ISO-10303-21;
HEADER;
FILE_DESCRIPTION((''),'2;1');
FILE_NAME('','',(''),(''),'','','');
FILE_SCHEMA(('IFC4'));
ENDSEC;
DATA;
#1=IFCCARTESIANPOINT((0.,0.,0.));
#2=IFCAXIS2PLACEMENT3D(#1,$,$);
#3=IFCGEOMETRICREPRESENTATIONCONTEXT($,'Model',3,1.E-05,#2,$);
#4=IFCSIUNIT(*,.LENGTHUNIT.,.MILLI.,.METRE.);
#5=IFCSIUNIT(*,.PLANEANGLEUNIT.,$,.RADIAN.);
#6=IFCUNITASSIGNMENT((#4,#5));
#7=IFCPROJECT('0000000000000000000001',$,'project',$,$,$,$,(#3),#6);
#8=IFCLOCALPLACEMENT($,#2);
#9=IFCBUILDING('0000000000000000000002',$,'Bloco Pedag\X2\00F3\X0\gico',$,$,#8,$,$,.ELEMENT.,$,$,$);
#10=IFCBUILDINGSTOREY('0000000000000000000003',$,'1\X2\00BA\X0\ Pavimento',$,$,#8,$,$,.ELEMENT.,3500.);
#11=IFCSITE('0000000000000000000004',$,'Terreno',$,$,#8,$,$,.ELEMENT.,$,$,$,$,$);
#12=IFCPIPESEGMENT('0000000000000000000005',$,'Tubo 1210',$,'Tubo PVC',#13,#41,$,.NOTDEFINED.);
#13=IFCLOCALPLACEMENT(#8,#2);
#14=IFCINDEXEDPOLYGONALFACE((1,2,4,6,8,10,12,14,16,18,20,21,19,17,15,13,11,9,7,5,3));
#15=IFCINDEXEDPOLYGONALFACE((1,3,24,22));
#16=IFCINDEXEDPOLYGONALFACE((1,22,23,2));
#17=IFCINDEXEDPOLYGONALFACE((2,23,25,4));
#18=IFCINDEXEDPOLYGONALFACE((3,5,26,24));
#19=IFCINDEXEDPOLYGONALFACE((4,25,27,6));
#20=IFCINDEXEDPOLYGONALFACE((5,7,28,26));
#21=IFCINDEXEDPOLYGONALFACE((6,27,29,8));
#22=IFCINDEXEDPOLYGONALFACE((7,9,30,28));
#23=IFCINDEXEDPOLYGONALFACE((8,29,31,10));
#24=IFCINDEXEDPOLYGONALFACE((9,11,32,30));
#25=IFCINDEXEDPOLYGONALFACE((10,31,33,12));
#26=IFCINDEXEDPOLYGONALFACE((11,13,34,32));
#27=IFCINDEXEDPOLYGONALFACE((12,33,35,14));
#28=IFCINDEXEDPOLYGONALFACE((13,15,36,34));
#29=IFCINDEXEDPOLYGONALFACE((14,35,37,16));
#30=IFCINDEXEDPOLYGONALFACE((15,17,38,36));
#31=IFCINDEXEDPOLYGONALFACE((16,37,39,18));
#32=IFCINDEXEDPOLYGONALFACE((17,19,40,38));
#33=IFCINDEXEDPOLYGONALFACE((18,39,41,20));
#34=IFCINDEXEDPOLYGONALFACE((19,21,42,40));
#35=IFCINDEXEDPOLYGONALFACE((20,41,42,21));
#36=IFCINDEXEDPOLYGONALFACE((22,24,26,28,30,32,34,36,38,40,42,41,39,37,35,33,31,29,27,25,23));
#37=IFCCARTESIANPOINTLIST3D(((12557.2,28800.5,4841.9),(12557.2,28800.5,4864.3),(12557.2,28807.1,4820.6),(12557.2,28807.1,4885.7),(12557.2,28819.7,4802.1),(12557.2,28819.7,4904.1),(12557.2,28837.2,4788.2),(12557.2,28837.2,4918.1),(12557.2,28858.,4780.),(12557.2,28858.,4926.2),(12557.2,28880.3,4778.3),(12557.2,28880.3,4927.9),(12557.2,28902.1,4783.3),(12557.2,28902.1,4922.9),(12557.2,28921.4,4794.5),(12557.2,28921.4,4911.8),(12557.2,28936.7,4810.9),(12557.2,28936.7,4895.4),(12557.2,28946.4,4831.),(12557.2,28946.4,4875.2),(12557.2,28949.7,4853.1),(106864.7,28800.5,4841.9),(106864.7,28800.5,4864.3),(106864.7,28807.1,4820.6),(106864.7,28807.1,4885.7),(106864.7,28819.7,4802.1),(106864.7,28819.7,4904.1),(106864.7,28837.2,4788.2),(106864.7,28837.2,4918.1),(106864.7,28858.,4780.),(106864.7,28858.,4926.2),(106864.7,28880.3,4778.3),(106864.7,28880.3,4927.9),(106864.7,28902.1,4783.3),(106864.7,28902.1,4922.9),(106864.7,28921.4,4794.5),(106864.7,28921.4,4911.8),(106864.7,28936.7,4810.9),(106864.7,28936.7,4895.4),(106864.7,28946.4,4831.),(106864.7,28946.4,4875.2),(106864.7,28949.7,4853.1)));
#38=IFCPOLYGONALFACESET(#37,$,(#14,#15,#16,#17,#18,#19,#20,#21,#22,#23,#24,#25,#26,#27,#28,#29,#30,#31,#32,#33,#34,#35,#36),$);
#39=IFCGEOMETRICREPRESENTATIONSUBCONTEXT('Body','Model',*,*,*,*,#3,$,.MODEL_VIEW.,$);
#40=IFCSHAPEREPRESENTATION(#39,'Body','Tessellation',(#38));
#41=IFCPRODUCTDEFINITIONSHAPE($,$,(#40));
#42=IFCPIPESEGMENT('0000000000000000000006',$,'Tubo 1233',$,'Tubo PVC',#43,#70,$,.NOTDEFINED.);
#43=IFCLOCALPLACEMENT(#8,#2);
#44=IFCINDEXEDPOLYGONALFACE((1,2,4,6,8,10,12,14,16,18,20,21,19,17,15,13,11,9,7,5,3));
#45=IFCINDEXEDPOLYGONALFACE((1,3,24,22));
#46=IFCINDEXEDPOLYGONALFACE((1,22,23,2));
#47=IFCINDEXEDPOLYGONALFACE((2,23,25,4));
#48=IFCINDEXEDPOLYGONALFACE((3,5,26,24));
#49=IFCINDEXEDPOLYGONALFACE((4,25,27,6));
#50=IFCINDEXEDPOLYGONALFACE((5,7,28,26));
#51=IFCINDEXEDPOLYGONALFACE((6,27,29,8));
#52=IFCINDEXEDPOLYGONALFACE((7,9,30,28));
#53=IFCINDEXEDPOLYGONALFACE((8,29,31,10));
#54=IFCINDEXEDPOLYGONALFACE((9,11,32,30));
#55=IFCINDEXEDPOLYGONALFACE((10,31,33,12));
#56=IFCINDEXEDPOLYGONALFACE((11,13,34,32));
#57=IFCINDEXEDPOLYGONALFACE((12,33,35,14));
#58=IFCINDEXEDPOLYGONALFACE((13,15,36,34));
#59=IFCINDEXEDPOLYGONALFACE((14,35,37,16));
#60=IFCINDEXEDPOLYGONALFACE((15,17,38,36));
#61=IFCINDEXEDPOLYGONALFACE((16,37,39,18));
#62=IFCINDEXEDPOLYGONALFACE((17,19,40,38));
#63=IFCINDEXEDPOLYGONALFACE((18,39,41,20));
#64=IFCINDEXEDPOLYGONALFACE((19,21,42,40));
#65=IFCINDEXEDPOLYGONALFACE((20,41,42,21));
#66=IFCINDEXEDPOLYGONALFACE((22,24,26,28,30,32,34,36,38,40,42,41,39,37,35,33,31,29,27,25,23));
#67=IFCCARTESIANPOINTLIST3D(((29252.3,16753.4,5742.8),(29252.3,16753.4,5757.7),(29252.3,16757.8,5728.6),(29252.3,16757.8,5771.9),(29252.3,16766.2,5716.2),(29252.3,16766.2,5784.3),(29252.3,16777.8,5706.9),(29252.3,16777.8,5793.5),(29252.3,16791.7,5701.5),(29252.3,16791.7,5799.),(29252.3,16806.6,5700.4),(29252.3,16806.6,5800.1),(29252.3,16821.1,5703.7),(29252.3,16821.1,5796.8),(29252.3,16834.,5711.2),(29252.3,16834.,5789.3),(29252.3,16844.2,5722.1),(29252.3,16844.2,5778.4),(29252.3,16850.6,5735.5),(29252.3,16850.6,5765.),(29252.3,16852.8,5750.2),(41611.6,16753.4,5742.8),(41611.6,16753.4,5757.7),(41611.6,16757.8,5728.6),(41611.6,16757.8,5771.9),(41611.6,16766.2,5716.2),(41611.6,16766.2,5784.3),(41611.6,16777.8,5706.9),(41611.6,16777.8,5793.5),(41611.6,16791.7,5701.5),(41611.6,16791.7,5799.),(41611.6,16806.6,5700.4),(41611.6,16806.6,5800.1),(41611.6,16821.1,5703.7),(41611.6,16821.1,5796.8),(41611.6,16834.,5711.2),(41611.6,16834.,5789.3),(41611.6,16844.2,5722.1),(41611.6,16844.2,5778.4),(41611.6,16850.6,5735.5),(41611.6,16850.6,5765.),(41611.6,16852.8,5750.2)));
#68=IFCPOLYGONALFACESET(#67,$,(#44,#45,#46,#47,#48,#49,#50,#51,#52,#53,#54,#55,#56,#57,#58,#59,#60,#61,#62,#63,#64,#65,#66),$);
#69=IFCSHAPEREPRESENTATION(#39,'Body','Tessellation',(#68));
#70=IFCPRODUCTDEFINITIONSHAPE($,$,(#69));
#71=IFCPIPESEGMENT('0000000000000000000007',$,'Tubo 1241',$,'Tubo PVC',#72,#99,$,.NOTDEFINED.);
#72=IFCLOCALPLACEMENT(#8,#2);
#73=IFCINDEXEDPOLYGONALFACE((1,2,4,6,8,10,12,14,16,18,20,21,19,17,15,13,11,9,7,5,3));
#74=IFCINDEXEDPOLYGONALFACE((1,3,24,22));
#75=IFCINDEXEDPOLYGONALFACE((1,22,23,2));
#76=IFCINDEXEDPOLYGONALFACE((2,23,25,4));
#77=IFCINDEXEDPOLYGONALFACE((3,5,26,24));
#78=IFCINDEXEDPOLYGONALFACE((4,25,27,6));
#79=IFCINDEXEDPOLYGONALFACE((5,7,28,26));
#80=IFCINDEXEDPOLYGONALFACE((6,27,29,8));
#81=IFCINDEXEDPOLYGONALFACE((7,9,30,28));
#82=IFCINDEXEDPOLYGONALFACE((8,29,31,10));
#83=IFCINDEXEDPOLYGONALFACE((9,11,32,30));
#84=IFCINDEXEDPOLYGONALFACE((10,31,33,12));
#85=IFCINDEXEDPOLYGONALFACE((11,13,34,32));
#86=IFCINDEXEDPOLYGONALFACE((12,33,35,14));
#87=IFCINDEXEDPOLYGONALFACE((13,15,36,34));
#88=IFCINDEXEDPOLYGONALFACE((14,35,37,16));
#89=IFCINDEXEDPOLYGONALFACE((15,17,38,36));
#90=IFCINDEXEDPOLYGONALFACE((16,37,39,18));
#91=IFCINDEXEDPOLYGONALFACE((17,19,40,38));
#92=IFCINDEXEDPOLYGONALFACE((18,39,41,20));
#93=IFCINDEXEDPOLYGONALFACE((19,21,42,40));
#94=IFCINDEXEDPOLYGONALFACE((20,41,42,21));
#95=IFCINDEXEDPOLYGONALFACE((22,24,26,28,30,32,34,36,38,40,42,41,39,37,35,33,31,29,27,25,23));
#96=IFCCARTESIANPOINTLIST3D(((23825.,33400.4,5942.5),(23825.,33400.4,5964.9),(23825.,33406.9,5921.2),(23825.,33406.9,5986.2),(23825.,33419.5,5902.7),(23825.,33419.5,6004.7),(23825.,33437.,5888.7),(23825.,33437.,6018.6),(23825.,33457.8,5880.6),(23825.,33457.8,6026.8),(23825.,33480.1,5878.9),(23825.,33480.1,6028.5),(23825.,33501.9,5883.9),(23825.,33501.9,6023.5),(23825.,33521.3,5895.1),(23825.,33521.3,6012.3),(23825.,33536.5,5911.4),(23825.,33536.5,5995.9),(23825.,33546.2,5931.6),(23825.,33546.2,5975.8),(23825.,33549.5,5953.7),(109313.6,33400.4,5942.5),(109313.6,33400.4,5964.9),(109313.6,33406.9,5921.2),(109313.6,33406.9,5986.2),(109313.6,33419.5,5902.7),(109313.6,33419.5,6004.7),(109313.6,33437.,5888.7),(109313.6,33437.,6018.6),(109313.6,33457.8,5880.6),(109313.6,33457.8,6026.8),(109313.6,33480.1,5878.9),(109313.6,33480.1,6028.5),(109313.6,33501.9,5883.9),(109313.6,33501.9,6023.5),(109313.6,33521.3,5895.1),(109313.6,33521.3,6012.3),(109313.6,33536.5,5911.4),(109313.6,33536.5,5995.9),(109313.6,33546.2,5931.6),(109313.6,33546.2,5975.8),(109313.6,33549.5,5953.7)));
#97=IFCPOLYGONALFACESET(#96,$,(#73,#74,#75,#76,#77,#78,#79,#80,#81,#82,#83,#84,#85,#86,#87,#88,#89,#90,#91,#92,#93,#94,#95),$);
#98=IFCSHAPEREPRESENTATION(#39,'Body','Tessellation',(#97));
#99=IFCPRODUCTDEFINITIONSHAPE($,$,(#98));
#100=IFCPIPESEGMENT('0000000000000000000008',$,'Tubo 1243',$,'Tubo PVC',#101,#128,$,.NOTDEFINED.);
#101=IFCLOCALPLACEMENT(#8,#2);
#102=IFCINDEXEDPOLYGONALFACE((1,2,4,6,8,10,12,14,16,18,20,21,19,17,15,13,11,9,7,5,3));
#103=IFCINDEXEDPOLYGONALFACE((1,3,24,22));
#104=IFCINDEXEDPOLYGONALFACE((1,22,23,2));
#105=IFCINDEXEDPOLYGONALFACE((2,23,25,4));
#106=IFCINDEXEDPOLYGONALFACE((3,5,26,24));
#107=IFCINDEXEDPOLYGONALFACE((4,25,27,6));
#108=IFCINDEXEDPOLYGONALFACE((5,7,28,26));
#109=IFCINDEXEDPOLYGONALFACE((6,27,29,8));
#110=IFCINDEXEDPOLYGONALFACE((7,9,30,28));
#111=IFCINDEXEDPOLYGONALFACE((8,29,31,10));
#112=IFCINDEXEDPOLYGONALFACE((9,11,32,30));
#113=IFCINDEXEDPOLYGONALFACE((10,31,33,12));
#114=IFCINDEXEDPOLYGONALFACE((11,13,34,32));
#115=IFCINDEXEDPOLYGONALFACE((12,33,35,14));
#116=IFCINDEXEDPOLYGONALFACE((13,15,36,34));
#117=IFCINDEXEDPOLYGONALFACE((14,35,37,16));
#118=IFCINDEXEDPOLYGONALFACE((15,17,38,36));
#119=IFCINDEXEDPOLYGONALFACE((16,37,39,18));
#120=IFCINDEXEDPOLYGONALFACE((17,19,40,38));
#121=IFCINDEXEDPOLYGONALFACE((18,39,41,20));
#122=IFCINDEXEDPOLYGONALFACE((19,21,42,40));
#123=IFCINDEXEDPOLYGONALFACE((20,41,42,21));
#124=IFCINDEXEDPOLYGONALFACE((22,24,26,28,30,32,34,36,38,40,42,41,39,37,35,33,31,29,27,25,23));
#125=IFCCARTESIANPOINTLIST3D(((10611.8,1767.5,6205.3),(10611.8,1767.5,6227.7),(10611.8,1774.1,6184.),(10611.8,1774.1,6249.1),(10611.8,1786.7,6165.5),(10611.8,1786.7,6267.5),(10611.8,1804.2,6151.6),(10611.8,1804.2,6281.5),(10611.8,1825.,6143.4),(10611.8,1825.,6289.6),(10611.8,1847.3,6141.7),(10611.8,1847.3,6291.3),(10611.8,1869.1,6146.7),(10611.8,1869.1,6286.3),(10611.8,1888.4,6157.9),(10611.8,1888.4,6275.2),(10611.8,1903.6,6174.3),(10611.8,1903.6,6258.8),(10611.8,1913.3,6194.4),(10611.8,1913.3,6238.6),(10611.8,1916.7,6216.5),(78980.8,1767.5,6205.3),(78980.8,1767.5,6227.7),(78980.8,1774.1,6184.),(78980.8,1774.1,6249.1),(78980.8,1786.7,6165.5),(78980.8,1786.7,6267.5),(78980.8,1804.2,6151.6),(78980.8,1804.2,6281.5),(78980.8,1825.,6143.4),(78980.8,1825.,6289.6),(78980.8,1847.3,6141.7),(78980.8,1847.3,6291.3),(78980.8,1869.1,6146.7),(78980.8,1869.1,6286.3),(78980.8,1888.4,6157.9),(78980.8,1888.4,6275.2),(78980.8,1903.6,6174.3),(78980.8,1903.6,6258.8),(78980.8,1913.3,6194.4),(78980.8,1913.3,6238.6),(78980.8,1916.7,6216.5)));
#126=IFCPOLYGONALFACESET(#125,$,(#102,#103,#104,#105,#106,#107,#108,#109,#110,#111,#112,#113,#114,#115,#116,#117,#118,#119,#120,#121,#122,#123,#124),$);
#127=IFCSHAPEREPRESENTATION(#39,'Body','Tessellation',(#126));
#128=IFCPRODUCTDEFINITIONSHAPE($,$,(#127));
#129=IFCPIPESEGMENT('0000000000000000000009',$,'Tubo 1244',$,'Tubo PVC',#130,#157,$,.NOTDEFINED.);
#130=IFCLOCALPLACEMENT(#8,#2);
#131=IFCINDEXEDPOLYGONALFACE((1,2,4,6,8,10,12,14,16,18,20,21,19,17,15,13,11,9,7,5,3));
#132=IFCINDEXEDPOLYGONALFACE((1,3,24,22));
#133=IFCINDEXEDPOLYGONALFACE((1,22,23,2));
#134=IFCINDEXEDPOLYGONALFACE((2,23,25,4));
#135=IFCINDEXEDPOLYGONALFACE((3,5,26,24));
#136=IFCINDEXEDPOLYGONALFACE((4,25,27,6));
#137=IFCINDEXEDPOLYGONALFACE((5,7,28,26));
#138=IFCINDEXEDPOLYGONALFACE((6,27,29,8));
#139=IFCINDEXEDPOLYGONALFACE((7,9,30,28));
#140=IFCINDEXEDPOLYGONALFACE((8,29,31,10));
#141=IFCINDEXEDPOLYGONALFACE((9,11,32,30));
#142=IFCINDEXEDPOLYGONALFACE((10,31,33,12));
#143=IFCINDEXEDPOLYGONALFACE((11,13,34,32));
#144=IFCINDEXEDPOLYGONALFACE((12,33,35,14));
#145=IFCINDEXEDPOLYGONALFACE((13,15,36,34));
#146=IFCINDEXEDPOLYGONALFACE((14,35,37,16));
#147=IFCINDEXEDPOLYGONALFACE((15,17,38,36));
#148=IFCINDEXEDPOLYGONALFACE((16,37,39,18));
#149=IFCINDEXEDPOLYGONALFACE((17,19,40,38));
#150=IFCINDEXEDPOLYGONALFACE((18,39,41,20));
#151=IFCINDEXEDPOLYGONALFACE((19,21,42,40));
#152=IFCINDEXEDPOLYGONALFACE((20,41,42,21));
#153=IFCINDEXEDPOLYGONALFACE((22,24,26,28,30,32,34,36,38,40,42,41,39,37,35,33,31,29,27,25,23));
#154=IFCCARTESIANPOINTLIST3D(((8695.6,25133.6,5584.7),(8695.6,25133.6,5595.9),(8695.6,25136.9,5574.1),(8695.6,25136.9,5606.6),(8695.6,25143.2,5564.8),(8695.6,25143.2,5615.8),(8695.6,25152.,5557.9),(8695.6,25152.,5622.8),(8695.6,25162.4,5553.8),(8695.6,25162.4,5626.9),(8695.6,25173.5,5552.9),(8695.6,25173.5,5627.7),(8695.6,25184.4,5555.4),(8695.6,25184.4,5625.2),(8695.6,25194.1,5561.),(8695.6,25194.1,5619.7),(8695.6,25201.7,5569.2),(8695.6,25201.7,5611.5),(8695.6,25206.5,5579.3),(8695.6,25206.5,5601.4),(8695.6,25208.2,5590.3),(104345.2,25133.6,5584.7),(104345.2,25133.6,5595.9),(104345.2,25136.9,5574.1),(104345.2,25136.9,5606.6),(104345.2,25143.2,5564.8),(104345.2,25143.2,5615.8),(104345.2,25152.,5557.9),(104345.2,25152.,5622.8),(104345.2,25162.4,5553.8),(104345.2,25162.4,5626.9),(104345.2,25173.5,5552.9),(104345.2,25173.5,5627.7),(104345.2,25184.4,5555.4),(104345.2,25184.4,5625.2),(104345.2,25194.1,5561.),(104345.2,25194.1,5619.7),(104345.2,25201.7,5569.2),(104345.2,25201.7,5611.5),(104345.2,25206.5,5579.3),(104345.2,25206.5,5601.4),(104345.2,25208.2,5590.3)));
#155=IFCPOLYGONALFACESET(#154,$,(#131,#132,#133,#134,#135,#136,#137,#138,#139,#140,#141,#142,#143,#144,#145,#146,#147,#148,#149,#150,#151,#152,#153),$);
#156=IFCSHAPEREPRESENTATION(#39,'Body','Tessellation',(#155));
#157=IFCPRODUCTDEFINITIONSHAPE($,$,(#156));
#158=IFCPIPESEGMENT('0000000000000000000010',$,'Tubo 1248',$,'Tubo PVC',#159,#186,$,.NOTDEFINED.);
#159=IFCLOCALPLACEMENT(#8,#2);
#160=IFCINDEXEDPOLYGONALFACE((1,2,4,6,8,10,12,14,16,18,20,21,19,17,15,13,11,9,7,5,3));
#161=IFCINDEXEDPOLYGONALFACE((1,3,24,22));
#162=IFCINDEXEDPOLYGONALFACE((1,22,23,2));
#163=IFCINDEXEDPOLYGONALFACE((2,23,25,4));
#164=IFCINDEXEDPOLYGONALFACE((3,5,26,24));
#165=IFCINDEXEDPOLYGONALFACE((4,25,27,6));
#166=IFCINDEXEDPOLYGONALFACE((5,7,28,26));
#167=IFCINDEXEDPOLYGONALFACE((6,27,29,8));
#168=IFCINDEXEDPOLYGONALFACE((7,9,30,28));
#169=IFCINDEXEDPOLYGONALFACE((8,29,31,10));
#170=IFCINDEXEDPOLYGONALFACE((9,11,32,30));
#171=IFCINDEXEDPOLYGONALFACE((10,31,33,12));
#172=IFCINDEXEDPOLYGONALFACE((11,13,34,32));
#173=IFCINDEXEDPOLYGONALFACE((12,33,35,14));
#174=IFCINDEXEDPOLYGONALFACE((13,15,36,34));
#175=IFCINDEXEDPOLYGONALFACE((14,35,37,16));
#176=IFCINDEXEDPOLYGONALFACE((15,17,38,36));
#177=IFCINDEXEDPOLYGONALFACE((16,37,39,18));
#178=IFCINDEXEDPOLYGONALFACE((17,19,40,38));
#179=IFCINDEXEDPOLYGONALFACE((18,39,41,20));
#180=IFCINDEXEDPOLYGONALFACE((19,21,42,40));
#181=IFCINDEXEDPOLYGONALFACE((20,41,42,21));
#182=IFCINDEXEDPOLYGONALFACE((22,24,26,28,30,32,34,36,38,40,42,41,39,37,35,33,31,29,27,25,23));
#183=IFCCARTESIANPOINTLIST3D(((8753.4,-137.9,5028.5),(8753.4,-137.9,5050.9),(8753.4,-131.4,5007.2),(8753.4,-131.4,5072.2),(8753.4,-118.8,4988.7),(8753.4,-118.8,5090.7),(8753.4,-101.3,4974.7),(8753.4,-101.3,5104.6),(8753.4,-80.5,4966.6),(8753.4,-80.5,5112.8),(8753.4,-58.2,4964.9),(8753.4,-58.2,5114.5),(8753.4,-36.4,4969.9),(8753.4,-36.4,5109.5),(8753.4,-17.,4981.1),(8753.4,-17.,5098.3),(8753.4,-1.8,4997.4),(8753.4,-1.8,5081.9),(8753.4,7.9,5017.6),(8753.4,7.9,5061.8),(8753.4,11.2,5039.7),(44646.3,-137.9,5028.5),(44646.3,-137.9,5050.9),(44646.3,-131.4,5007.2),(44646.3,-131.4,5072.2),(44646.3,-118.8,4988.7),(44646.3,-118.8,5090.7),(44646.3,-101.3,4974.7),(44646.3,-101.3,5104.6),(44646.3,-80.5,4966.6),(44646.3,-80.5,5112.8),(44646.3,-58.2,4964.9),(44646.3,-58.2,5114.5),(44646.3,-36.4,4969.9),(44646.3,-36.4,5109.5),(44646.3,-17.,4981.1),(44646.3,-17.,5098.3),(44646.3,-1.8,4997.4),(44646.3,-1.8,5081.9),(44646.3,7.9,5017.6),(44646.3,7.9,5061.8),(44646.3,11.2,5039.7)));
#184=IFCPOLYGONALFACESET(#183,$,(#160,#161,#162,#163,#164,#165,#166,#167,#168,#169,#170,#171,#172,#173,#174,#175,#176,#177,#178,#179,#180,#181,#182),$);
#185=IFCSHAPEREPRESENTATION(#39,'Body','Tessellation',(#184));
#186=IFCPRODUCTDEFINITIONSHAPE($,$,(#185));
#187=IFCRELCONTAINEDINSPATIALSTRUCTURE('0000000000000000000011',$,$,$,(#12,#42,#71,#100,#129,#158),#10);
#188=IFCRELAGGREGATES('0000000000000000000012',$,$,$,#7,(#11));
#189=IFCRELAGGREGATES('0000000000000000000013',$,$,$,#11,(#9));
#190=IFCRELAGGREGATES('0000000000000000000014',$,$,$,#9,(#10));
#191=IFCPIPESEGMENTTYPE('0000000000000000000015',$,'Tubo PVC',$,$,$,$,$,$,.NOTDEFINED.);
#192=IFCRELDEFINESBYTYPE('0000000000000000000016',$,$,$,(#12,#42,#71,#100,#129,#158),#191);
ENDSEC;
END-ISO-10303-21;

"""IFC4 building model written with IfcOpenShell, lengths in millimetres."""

from ifc_helpers import new_model, si_unit, frame, origin, origin_2d, place, context, subcontext, project, spatial, circle, extrude, type_object, element, save


model = new_model("IFC4")

# Units and contexts
model_context = context("Model", 3, precision=1e-05, world=origin())
body_context = subcontext(model_context, "Body", "Model", "MODEL_VIEW")
ifc_project = project(units=[si_unit("LENGTHUNIT", "METRE", prefix="MILLI"), si_unit("PLANEANGLEUNIT", "RADIAN")], contexts=[model_context])

# Site, building, storey
placement = place(None, origin())
site = spatial("IfcSite", under=ifc_project, at=placement, Name="Terreno", CompositionType="ELEMENT")
building = spatial("IfcBuilding", under=site, at=placement, Name="Bloco Pedagógico", CompositionType="ELEMENT")
storey = spatial("IfcBuildingStorey", under=building, at=placement, Name="1º Pavimento", CompositionType="ELEMENT", Elevation=3500.0)

# Pipe segments
pipe_segment_type = type_object("IfcPipeSegmentType", Name="Tubo PVC", PredefinedType="NOTDEFINED")
pipe_segment_1_placement = place(None, frame((12557.2, 28874.7, 4853.1), z_axis=(1.0, 0.0, 0.0), x_axis=(0.0, 1.0, 0.0)))
element("IfcPipeSegment", 1, at=pipe_segment_1_placement, inside=storey, type_object=pipe_segment_type, Name="Tubo 1210", ObjectType="Tubo PVC", PredefinedType="NOTDEFINED", context=body_context, shape_type="SweptSolid", body=[
    extrude(circle(Radius=75.0, at=origin_2d()), None, (0.0, 0.0, 1.0), 94307.5),
])
pipe_segment_2_placement = place(None, frame((29252.3, 16802.8, 5750.2), z_axis=(1.0, 0.0, 0.0), x_axis=(0.0, 1.0, 0.0)))
element("IfcPipeSegment", 2, at=pipe_segment_2_placement, inside=storey, type_object=pipe_segment_type, Name="Tubo 1233", ObjectType="Tubo PVC", PredefinedType="NOTDEFINED", context=body_context, shape_type="SweptSolid", body=[
    extrude(circle(Radius=50.0, at=origin_2d()), None, (0.0, 0.0, 1.0), 12359.3),
])
pipe_segment_3_placement = place(None, frame((23825.0, 33474.5, 5953.7), z_axis=(1.0, 0.0, 0.0), x_axis=(0.0, 1.0, 0.0)))
element("IfcPipeSegment", 3, at=pipe_segment_3_placement, inside=storey, type_object=pipe_segment_type, Name="Tubo 1241", ObjectType="Tubo PVC", PredefinedType="NOTDEFINED", context=body_context, shape_type="SweptSolid", body=[
    extrude(circle(Radius=75.0, at=origin_2d()), None, (0.0, 0.0, 1.0), 85488.6),
])
pipe_segment_4_placement = place(None, frame((10611.8, 1841.7, 6216.5), z_axis=(1.0, 0.0, 0.0), x_axis=(0.0, 1.0, 0.0)))
element("IfcPipeSegment", 4, at=pipe_segment_4_placement, inside=storey, type_object=pipe_segment_type, Name="Tubo 1243", ObjectType="Tubo PVC", PredefinedType="NOTDEFINED", context=body_context, shape_type="SweptSolid", body=[
    extrude(circle(Radius=75.0, at=origin_2d()), None, (0.0, 0.0, 1.0), 68369.1),
])
pipe_segment_5_placement = place(None, frame((8695.6, 25170.7, 5590.3), z_axis=(1.0, 0.0, 0.0), x_axis=(0.0, 1.0, 0.0)))
element("IfcPipeSegment", 5, at=pipe_segment_5_placement, inside=storey, type_object=pipe_segment_type, Name="Tubo 1244", ObjectType="Tubo PVC", PredefinedType="NOTDEFINED", context=body_context, shape_type="SweptSolid", body=[
    extrude(circle(Radius=37.5, at=origin_2d()), None, (0.0, 0.0, 1.0), 95649.6),
])
pipe_segment_6_placement = place(None, frame((8753.4, -63.8, 5039.7), z_axis=(1.0, 0.0, 0.0), x_axis=(0.0, 1.0, 0.0)))
element("IfcPipeSegment", 6, at=pipe_segment_6_placement, inside=storey, type_object=pipe_segment_type, Name="Tubo 1248", ObjectType="Tubo PVC", PredefinedType="NOTDEFINED", context=body_context, shape_type="SweptSolid", body=[
    extrude(circle(Radius=75.0, at=origin_2d()), None, (0.0, 0.0, 1.0), 35892.9),
])

save(model, "model.ifc")
